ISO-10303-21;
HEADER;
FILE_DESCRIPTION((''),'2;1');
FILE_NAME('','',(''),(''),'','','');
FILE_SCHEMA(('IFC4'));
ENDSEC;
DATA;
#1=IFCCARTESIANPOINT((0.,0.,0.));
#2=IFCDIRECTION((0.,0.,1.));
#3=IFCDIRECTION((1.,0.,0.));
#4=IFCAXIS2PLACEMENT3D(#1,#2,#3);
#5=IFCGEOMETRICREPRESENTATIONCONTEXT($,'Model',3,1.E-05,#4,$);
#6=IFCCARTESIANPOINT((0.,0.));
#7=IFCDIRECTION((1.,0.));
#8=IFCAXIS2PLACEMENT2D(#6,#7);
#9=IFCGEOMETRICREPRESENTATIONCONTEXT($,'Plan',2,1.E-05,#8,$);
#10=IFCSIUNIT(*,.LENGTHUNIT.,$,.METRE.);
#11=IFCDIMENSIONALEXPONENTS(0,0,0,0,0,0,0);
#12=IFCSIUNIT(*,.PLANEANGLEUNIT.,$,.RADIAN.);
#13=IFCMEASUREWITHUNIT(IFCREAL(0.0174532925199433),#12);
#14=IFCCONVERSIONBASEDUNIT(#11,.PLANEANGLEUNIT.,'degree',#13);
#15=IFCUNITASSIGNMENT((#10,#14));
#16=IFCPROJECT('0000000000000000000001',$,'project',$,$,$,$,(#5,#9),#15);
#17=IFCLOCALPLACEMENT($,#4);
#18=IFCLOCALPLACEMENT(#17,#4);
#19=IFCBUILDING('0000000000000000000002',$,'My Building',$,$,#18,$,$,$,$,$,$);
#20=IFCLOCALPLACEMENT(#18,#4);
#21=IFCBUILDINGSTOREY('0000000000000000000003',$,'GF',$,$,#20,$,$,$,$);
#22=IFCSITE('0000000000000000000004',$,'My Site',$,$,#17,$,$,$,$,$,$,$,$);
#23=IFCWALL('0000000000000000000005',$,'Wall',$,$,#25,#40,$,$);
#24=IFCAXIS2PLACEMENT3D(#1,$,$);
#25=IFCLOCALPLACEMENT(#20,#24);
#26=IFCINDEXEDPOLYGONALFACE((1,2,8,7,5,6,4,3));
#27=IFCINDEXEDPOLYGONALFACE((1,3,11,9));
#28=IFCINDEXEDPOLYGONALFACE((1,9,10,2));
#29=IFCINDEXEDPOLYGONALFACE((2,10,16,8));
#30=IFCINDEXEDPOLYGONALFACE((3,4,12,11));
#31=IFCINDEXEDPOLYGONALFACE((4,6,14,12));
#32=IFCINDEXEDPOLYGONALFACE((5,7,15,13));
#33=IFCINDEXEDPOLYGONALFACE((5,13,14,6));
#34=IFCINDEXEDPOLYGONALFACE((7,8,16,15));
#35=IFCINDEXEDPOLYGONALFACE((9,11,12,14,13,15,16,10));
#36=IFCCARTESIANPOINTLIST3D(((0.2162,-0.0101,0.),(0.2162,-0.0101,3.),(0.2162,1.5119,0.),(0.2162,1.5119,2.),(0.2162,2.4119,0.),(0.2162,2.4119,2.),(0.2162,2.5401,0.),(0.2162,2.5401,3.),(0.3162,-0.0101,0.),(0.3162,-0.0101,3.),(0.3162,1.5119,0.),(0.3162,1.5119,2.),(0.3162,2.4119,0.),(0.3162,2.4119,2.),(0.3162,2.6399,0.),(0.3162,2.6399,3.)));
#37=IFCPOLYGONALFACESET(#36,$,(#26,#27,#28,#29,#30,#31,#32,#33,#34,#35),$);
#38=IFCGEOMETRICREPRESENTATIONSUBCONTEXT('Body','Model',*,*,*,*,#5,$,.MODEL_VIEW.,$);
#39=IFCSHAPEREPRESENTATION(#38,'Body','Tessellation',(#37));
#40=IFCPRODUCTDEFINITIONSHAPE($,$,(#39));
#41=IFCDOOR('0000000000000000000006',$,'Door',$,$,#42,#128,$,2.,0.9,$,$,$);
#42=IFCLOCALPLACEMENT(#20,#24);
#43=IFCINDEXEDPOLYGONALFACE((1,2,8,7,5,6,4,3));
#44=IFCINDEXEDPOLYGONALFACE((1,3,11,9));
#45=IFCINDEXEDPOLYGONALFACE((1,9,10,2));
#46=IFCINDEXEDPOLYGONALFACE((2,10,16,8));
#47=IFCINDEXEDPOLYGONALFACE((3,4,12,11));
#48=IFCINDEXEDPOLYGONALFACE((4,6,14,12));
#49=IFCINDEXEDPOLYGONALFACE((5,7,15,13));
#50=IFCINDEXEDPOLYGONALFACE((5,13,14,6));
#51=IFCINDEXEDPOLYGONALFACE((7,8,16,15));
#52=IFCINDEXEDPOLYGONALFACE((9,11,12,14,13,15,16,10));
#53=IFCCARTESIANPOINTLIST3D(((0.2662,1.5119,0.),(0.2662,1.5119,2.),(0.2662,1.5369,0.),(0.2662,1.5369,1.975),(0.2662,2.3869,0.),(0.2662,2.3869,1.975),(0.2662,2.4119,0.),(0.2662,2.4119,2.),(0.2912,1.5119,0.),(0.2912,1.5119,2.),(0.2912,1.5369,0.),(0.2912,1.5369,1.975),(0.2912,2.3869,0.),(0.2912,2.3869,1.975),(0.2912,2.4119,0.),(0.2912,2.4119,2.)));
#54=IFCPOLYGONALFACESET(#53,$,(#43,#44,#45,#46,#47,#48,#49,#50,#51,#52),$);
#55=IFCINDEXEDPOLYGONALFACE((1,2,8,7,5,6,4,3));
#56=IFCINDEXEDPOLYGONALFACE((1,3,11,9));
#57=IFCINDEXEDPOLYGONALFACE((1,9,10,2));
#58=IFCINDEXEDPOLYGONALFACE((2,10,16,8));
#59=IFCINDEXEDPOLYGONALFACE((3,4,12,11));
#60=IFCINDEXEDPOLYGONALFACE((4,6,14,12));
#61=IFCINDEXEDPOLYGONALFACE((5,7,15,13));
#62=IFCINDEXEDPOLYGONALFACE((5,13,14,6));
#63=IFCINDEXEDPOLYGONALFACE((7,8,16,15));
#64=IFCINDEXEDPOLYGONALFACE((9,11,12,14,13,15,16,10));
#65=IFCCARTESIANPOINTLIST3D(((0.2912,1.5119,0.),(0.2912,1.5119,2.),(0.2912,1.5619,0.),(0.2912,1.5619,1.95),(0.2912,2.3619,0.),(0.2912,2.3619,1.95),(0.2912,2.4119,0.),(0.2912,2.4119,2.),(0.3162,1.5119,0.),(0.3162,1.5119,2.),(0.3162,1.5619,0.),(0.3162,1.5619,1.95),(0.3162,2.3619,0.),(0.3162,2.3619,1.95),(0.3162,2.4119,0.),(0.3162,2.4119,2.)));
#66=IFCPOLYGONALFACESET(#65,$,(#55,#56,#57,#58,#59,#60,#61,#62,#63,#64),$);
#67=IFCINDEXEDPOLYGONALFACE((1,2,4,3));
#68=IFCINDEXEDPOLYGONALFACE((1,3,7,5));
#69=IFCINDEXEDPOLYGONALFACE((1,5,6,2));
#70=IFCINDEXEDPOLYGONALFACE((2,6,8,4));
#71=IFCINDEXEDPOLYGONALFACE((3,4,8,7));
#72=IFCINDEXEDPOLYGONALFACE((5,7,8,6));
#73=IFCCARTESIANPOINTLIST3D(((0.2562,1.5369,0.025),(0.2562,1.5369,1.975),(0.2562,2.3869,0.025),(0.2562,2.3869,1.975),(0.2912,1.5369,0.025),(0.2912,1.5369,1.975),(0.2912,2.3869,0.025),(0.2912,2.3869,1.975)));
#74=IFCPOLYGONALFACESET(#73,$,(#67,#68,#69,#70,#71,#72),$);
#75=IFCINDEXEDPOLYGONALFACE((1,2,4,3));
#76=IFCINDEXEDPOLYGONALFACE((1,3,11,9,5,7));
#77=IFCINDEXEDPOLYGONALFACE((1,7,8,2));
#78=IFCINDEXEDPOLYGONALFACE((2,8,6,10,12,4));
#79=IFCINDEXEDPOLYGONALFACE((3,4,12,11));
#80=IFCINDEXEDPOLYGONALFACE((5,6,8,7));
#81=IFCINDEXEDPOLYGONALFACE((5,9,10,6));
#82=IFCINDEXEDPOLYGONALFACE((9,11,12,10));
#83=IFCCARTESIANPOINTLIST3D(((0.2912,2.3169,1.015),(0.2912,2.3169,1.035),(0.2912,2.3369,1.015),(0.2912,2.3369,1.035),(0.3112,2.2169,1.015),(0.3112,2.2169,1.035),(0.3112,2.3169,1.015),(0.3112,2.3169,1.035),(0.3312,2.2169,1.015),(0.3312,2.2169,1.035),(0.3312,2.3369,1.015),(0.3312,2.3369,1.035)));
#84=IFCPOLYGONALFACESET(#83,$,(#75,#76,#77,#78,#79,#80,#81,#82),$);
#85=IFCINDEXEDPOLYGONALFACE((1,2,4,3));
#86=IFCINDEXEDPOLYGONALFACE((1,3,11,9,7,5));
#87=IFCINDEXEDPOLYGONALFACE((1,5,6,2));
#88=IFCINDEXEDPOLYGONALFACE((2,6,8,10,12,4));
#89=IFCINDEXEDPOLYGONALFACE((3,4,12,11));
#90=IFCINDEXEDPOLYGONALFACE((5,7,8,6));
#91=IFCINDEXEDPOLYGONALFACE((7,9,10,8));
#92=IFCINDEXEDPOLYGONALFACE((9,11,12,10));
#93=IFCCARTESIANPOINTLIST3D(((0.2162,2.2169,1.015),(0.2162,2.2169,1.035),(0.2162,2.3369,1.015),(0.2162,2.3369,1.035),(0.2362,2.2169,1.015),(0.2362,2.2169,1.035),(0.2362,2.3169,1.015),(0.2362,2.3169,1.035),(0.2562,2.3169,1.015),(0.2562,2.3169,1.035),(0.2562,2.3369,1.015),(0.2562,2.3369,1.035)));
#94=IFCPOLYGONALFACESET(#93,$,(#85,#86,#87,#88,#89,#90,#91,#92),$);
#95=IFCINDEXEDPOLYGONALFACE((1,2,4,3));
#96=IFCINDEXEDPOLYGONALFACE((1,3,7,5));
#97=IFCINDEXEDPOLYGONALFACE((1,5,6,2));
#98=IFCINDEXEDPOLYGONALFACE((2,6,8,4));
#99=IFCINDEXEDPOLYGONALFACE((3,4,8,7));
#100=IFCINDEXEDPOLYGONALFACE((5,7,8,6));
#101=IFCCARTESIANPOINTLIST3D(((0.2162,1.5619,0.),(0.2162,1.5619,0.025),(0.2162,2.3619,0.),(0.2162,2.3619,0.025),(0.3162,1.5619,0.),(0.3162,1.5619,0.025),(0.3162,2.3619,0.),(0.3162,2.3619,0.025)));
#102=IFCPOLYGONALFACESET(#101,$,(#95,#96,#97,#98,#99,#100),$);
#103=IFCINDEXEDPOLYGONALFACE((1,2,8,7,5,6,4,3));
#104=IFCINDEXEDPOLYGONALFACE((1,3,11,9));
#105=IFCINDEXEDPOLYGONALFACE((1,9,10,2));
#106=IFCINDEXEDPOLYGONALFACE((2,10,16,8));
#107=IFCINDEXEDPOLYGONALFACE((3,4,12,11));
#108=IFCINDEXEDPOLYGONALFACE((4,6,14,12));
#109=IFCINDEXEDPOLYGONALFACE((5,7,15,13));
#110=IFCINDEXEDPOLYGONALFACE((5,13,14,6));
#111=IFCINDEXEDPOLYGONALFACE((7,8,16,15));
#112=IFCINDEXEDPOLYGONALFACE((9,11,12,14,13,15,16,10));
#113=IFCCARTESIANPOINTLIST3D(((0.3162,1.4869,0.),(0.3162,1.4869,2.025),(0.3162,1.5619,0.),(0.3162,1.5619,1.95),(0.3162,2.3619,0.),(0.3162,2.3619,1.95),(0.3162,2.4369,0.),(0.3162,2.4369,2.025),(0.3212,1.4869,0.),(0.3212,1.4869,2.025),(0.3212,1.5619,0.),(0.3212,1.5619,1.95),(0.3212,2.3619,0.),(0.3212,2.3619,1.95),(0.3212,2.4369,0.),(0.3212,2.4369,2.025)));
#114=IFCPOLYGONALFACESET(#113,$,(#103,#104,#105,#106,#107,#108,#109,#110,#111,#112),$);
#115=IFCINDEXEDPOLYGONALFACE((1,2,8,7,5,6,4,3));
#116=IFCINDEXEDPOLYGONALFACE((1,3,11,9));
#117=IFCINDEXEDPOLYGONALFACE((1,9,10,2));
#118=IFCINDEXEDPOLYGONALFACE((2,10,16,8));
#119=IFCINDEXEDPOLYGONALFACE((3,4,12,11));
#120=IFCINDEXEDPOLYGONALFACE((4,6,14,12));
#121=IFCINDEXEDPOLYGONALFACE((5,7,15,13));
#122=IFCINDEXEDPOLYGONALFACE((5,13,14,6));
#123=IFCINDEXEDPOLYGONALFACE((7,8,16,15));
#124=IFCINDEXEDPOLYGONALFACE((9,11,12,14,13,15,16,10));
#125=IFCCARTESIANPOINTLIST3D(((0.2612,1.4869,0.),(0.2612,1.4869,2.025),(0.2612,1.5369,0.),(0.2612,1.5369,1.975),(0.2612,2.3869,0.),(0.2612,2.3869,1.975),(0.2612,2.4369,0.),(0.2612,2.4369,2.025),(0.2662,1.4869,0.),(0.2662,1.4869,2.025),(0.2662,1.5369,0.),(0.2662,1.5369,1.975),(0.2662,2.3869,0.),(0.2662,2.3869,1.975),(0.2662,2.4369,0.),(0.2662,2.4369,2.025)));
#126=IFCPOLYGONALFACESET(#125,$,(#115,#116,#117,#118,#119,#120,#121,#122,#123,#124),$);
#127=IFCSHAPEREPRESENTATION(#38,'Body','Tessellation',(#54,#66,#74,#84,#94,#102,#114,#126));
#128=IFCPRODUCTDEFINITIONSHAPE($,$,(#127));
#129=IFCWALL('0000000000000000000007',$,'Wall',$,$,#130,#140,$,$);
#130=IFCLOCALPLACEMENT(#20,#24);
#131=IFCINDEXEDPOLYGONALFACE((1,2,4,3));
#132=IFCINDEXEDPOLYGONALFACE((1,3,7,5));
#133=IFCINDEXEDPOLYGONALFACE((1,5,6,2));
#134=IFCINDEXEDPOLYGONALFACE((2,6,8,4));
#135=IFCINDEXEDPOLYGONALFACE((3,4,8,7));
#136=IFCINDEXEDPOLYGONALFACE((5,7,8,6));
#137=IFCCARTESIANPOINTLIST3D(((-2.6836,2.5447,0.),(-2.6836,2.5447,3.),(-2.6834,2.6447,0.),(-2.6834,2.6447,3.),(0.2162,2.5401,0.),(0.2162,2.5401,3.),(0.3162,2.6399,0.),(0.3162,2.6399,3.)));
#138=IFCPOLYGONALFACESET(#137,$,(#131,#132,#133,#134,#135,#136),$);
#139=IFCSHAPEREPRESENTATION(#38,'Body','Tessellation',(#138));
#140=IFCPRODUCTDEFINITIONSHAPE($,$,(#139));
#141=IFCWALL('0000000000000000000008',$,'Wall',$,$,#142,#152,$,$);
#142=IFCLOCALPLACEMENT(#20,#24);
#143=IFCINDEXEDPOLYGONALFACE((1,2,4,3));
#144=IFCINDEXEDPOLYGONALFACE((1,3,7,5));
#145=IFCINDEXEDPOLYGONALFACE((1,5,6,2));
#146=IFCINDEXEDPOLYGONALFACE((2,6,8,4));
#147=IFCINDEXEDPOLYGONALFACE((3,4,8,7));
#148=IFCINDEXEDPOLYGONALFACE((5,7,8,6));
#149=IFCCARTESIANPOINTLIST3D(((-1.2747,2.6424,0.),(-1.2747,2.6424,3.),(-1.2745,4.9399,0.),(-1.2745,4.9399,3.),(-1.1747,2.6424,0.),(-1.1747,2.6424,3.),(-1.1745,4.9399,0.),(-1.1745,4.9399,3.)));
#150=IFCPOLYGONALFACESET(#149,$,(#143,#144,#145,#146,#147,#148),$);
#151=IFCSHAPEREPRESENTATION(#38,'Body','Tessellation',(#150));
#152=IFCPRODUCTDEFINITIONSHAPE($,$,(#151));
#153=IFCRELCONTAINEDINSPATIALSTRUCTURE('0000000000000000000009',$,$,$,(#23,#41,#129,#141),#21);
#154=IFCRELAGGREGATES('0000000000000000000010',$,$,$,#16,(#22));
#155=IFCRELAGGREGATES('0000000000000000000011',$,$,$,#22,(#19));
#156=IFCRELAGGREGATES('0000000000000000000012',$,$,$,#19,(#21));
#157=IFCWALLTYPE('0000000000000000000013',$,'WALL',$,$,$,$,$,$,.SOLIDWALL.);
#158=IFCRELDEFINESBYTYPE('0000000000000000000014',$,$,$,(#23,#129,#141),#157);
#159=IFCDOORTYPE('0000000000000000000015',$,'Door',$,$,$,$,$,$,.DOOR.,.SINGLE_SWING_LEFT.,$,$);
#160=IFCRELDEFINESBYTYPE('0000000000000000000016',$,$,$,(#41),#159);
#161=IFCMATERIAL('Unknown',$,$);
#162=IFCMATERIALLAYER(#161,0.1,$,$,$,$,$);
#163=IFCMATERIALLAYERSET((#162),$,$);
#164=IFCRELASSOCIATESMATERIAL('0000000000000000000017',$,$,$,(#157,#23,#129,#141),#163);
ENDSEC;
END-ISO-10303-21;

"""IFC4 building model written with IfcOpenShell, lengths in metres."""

from ifc_helpers import new_model, entity, si_unit, converted_unit, frame, origin_with_axes, origin_2d_with_axis, place, context, subcontext, project, spatial, line, indexed_curve, outline, extrude, shape, source, transform, mapped, material, layer, layer_set, layer_usage, type_object, type_shapes, element, fill, save


model = new_model("IFC4")

# Units and contexts
model_context = context("Model", 3, precision=1e-05, world=origin_with_axes())
plan_context = context("Plan", 2, precision=1e-05, world=origin_2d_with_axis())
body_context_1 = subcontext(model_context, "Body", "Model", "MODEL_VIEW")
body_context_2 = subcontext(plan_context, "Body", "Plan", "PLAN_VIEW")
ifc_project = project(units=[si_unit("LENGTHUNIT", "METRE"), converted_unit("PLANEANGLEUNIT", "degree", entity("IfcReal", 0.0174532925199433), si_unit("PLANEANGLEUNIT", "RADIAN"), dimensions=[0, 0, 0, 0, 0, 0, 0])], contexts=[model_context, plan_context])

# Site, building, storey
site_placement = place(None, origin_with_axes())
site = spatial("IfcSite", under=ifc_project, at=site_placement, Name="My Site")
building_placement = place(site_placement, origin_with_axes())
building = spatial("IfcBuilding", under=site, at=building_placement, Name="My Building")
storey_placement = place(building_placement, origin_with_axes())
storey = spatial("IfcBuildingStorey", under=building, at=storey_placement, Name="GF")

# Shared definitions
ifc_material_1 = material(Name="Unknown")

# Shared definitions
ifc_layer_1 = layer(ifc_material_1, 0.1)
ifc_layer_set_1 = layer_set([ifc_layer_1])
wall_type = type_object("IfcWallType", Name="WALL", PredefinedType="SOLIDWALL", material=ifc_layer_set_1)
shared_shape_1 = source(origin_with_axes(), body_context_1, "Body", "SweptSolid", [
    extrude(outline(indexed_curve([(0.0, 0.0), (0.9, 0.0), (0.9, 2.0), (0.0, 2.0)], segments=[line(1, 2, 3, 4, 1)])), frame((0.0, -0.6, 0.0), z_axis=(0.0, -1.0, 0.0), x_axis=(1.0, 0.0, 0.0)), (0.0, 0.0, -1.0), 1.2),
])
door_type = type_object("IfcDoorType", Name="Door", OperationType="SINGLE_SWING_LEFT", PredefinedType="DOOR")
shared_shape_2 = source(origin_with_axes(), body_context_1, "Body", "SweptSolid", [
    extrude(outline(indexed_curve([(0.0, 0.0), (0.0, 2.0), (0.9, 2.0), (0.9, 0.0), (0.875, 0.0), (0.875, 1.975), (0.025, 1.975), (0.025, 0.0)], segments=[line(1, 2, 3, 4, 5, 6, 7, 8, 1)])), frame((0.0, 0.025, 0.0), z_axis=(0.0, -1.0, 0.0), x_axis=(1.0, 0.0, 0.0)), (0.0, 0.0, -1.0), 0.025),
    extrude(outline(indexed_curve([(0.0, 0.0), (0.0, 2.0), (0.9, 2.0), (0.9, 0.0), (0.85, 0.0), (0.85, 1.95), (0.05, 1.95), (0.05, 0.0)], segments=[line(1, 2, 3, 4, 5, 6, 7, 8, 1)])), frame((0.0, 0.0, 0.0), z_axis=(0.0, -1.0, 0.0), x_axis=(1.0, 0.0, 0.0)), (0.0, 0.0, -1.0), 0.025),
    extrude(outline(indexed_curve([(0.0, 0.0), (0.85, 0.0), (0.85, 0.035), (0.0, 0.035)], segments=[line(1, 2, 3, 4, 1)])), frame((0.025, 0.025, 0.025), z_axis=(0.0, 0.0, 1.0), x_axis=(1.0, 0.0, 0.0)), (0.0, 0.0, 1.0), 1.95),
    extrude(outline(indexed_curve([(0.0, 0.0), (0.0, -0.04), (-0.12, -0.04), (-0.12, -0.02), (-0.02, -0.02), (-0.02, 0.0)], segments=[line(1, 2, 3, 4, 5, 6, 1)])), frame((0.825, 0.025, 1.015), z_axis=(0.0, 0.0, 1.0), x_axis=(1.0, 0.0, 0.0)), (0.0, 0.0, 1.0), 0.02),
    extrude(outline(indexed_curve([(0.0, 0.0), (0.0, 0.04), (-0.12, 0.04), (-0.12, 0.02), (-0.02, 0.02), (-0.02, 0.0)], segments=[line(1, 2, 3, 4, 5, 6, 1)])), frame((0.825, 0.06, 1.015), z_axis=(0.0, 0.0, 1.0), x_axis=(1.0, 0.0, 0.0)), (0.0, 0.0, 1.0), 0.02),
    extrude(outline(indexed_curve([(0.0, 0.0), (0.8, 0.0), (0.8, 0.1), (0.0, 0.1)], segments=[line(1, 2, 3, 4, 1)])), frame((0.05, 0.0, 0.0), z_axis=(0.0, 0.0, 1.0), x_axis=(1.0, 0.0, 0.0)), (0.0, 0.0, 1.0), 0.025),
    extrude(outline(indexed_curve([(0.0, 0.0), (0.0, 2.025), (0.95, 2.025), (0.95, 0.0), (0.875, 0.0), (0.875, 1.95), (0.075, 1.95), (0.075, 0.0)], segments=[line(1, 2, 3, 4, 5, 6, 7, 8, 1)])), frame((-0.025, -0.005, 0.0), z_axis=(0.0, -1.0, 0.0), x_axis=(1.0, 0.0, 0.0)), (0.0, 0.0, -1.0), 0.005),
    extrude(outline(indexed_curve([(0.0, 0.0), (0.0, 2.025), (0.95, 2.025), (0.95, 0.0), (0.9, 0.0), (0.9, 1.975), (0.05, 1.975), (0.05, 0.0)], segments=[line(1, 2, 3, 4, 5, 6, 7, 8, 1)])), frame((-0.025, 0.05, 0.0), z_axis=(0.0, -1.0, 0.0), x_axis=(1.0, 0.0, 0.0)), (0.0, 0.0, -1.0), 0.005),
])
shared_shape_3 = source(origin_with_axes(), body_context_2, "Body", "Curve2D", [
    entity("IfcIndexedPolyCurve", entity("IfcCartesianPointList2D", [[0.0, 0.0], [0.0, 0.05], [0.025, 0.05], [0.025, 0.025], [0.05, 0.025], [0.05, 0.0]]), [entity("IfcLineIndex", [1, 2, 3, 4, 5, 6, 1])]),
    entity("IfcIndexedPolyCurve", entity("IfcCartesianPointList2D", [[0.9, 0.0], [0.9, 0.05], [0.875, 0.05], [0.875, 0.025], [0.85, 0.025], [0.85, 0.0]]), [entity("IfcLineIndex", [1, 2, 3, 4, 5, 6, 1])]),
    entity("IfcTrimmedCurve", entity("IfcEllipse", entity("IfcAxis2Placement2D", entity("IfcCartesianPoint", [0.06, 0.05]), entity("IfcDirection", [1.0, 0.0])), 0.815, 0.85), [entity("IfcCartesianPoint", [0.875, 0.05])], [entity("IfcCartesianPoint", [0.06, 0.9])], True, "CARTESIAN"),
    entity("IfcIndexedPolyCurve", entity("IfcCartesianPointList2D", [[0.025, 0.05], [0.06, 0.05], [0.06, 0.9], [0.025, 0.9]]), [entity("IfcLineIndex", [1, 2, 3, 4, 1])]),
])
type_shapes(door_type, [shared_shape_2, shared_shape_3])

# Wall, opening, door
ifc_layer_usage_1 = layer_usage(ifc_layer_set_1, "AXIS2", "POSITIVE", 0.0)
wall_1_placement = place(storey_placement, frame((0.3162, -0.0101, 0.0), z_axis=(0.0, 0.0, 1.0), x_axis=(0.0, 1.0, 0.0)))
wall_1 = element("IfcWall", 1, at=wall_1_placement, inside=storey, type_object=wall_type, material=ifc_layer_usage_1, Name="Wall", context=body_context_1, shape_type="SweptSolid", body=[
    extrude(outline(indexed_curve([(0.0, 0.0), (0.0, 0.1), (2.5502, 0.1), (2.65, 0.0)], segments=[line(1, 2, 3, 4, 1)])), origin_with_axes(), (0.0, 0.0, 1.0), 3.0),
])
opening_1_placement = place(wall_1_placement, frame((1.522, 0.0, 0.0), z_axis=(0.0, 0.0, 1.0), x_axis=(1.0, 0.0, 0.0)))
opening_1 = element("IfcOpeningElement", 2, at=opening_1_placement, cuts=wall_1, PredefinedType="OPENING", context=body_context_1, shape_type="MappedRepresentation", body=[
    mapped(shared_shape_1, transform((0.0, 0.0, 0.0), x_axis=(1.0, 0.0, 0.0), y_axis=(0.0, 1.0, 0.0), z_axis=(0.0, 0.0, 1.0), scale=1.0)),
])
door_1_placement = place(opening_1_placement, frame((0.0, 0.0, 0.0), z_axis=(0.0, 0.0, 1.0), x_axis=(1.0, 0.0, 0.0)))
door_1 = element("IfcDoor", 3, at=door_1_placement, inside=storey, type_object=door_type, Name="Door", OverallHeight=2.0, OverallWidth=0.9, shapes=[
    shape(body_context_1, "Body", "MappedRepresentation", [mapped(shared_shape_2, transform((0.0, 0.0, 0.0), x_axis=(1.0, 0.0, 0.0), y_axis=(0.0, 1.0, 0.0), z_axis=(0.0, 0.0, 1.0), scale=1.0))]),
    shape(body_context_2, "Body", "MappedRepresentation", [mapped(shared_shape_3, transform((0.0, 0.0, 0.0), x_axis=(1.0, 0.0, 0.0), y_axis=(0.0, 1.0, 0.0), z_axis=(0.0, 0.0, 1.0), scale=1.0))]),
])
fill(opening_1, door_1)

# Walls
ifc_layer_usage_2 = layer_usage(ifc_layer_set_1, "AXIS2", "POSITIVE", 0.0)
wall_2_placement = place(storey_placement, frame((0.3162, 2.6399, 0.0), z_axis=(0.0, 0.0, 1.0), x_axis=(-0.999999, 0.001594, 0.0)))
element("IfcWall", 4, at=wall_2_placement, inside=storey, type_object=wall_type, material=ifc_layer_usage_2, Name="Wall", context=body_context_1, shape_type="SweptSolid", body=[
    extrude(outline(indexed_curve([(0.0, 0.0), (0.0998, 0.1), (2.9996, 0.1), (2.9996, 0.0)], segments=[line(1, 2, 3, 4, 1)])), origin_with_axes(), (0.0, 0.0, 1.0), 3.0),
])
ifc_layer_usage_3 = layer_usage(ifc_layer_set_1, "AXIS2", "POSITIVE", 0.0)
wall_3_placement = place(storey_placement, frame((-1.2745, 4.9399, 0.0), z_axis=(0.0, 0.0, 1.0), x_axis=(-0.000123, -1.0, 0.0)))
element("IfcWall", 5, at=wall_3_placement, inside=storey, type_object=wall_type, material=ifc_layer_usage_3, Name="Wall", context=body_context_1, shape_type="SweptSolid", body=[
    extrude(outline(indexed_curve([(0.0, 0.0), (0.0, 0.1), (2.2975, 0.1), (2.2975, 0.0)], segments=[line(1, 2, 3, 4, 1)])), origin_with_axes(), (0.0, 0.0, 1.0), 3.0),
])

save(model, "model.ifc")
